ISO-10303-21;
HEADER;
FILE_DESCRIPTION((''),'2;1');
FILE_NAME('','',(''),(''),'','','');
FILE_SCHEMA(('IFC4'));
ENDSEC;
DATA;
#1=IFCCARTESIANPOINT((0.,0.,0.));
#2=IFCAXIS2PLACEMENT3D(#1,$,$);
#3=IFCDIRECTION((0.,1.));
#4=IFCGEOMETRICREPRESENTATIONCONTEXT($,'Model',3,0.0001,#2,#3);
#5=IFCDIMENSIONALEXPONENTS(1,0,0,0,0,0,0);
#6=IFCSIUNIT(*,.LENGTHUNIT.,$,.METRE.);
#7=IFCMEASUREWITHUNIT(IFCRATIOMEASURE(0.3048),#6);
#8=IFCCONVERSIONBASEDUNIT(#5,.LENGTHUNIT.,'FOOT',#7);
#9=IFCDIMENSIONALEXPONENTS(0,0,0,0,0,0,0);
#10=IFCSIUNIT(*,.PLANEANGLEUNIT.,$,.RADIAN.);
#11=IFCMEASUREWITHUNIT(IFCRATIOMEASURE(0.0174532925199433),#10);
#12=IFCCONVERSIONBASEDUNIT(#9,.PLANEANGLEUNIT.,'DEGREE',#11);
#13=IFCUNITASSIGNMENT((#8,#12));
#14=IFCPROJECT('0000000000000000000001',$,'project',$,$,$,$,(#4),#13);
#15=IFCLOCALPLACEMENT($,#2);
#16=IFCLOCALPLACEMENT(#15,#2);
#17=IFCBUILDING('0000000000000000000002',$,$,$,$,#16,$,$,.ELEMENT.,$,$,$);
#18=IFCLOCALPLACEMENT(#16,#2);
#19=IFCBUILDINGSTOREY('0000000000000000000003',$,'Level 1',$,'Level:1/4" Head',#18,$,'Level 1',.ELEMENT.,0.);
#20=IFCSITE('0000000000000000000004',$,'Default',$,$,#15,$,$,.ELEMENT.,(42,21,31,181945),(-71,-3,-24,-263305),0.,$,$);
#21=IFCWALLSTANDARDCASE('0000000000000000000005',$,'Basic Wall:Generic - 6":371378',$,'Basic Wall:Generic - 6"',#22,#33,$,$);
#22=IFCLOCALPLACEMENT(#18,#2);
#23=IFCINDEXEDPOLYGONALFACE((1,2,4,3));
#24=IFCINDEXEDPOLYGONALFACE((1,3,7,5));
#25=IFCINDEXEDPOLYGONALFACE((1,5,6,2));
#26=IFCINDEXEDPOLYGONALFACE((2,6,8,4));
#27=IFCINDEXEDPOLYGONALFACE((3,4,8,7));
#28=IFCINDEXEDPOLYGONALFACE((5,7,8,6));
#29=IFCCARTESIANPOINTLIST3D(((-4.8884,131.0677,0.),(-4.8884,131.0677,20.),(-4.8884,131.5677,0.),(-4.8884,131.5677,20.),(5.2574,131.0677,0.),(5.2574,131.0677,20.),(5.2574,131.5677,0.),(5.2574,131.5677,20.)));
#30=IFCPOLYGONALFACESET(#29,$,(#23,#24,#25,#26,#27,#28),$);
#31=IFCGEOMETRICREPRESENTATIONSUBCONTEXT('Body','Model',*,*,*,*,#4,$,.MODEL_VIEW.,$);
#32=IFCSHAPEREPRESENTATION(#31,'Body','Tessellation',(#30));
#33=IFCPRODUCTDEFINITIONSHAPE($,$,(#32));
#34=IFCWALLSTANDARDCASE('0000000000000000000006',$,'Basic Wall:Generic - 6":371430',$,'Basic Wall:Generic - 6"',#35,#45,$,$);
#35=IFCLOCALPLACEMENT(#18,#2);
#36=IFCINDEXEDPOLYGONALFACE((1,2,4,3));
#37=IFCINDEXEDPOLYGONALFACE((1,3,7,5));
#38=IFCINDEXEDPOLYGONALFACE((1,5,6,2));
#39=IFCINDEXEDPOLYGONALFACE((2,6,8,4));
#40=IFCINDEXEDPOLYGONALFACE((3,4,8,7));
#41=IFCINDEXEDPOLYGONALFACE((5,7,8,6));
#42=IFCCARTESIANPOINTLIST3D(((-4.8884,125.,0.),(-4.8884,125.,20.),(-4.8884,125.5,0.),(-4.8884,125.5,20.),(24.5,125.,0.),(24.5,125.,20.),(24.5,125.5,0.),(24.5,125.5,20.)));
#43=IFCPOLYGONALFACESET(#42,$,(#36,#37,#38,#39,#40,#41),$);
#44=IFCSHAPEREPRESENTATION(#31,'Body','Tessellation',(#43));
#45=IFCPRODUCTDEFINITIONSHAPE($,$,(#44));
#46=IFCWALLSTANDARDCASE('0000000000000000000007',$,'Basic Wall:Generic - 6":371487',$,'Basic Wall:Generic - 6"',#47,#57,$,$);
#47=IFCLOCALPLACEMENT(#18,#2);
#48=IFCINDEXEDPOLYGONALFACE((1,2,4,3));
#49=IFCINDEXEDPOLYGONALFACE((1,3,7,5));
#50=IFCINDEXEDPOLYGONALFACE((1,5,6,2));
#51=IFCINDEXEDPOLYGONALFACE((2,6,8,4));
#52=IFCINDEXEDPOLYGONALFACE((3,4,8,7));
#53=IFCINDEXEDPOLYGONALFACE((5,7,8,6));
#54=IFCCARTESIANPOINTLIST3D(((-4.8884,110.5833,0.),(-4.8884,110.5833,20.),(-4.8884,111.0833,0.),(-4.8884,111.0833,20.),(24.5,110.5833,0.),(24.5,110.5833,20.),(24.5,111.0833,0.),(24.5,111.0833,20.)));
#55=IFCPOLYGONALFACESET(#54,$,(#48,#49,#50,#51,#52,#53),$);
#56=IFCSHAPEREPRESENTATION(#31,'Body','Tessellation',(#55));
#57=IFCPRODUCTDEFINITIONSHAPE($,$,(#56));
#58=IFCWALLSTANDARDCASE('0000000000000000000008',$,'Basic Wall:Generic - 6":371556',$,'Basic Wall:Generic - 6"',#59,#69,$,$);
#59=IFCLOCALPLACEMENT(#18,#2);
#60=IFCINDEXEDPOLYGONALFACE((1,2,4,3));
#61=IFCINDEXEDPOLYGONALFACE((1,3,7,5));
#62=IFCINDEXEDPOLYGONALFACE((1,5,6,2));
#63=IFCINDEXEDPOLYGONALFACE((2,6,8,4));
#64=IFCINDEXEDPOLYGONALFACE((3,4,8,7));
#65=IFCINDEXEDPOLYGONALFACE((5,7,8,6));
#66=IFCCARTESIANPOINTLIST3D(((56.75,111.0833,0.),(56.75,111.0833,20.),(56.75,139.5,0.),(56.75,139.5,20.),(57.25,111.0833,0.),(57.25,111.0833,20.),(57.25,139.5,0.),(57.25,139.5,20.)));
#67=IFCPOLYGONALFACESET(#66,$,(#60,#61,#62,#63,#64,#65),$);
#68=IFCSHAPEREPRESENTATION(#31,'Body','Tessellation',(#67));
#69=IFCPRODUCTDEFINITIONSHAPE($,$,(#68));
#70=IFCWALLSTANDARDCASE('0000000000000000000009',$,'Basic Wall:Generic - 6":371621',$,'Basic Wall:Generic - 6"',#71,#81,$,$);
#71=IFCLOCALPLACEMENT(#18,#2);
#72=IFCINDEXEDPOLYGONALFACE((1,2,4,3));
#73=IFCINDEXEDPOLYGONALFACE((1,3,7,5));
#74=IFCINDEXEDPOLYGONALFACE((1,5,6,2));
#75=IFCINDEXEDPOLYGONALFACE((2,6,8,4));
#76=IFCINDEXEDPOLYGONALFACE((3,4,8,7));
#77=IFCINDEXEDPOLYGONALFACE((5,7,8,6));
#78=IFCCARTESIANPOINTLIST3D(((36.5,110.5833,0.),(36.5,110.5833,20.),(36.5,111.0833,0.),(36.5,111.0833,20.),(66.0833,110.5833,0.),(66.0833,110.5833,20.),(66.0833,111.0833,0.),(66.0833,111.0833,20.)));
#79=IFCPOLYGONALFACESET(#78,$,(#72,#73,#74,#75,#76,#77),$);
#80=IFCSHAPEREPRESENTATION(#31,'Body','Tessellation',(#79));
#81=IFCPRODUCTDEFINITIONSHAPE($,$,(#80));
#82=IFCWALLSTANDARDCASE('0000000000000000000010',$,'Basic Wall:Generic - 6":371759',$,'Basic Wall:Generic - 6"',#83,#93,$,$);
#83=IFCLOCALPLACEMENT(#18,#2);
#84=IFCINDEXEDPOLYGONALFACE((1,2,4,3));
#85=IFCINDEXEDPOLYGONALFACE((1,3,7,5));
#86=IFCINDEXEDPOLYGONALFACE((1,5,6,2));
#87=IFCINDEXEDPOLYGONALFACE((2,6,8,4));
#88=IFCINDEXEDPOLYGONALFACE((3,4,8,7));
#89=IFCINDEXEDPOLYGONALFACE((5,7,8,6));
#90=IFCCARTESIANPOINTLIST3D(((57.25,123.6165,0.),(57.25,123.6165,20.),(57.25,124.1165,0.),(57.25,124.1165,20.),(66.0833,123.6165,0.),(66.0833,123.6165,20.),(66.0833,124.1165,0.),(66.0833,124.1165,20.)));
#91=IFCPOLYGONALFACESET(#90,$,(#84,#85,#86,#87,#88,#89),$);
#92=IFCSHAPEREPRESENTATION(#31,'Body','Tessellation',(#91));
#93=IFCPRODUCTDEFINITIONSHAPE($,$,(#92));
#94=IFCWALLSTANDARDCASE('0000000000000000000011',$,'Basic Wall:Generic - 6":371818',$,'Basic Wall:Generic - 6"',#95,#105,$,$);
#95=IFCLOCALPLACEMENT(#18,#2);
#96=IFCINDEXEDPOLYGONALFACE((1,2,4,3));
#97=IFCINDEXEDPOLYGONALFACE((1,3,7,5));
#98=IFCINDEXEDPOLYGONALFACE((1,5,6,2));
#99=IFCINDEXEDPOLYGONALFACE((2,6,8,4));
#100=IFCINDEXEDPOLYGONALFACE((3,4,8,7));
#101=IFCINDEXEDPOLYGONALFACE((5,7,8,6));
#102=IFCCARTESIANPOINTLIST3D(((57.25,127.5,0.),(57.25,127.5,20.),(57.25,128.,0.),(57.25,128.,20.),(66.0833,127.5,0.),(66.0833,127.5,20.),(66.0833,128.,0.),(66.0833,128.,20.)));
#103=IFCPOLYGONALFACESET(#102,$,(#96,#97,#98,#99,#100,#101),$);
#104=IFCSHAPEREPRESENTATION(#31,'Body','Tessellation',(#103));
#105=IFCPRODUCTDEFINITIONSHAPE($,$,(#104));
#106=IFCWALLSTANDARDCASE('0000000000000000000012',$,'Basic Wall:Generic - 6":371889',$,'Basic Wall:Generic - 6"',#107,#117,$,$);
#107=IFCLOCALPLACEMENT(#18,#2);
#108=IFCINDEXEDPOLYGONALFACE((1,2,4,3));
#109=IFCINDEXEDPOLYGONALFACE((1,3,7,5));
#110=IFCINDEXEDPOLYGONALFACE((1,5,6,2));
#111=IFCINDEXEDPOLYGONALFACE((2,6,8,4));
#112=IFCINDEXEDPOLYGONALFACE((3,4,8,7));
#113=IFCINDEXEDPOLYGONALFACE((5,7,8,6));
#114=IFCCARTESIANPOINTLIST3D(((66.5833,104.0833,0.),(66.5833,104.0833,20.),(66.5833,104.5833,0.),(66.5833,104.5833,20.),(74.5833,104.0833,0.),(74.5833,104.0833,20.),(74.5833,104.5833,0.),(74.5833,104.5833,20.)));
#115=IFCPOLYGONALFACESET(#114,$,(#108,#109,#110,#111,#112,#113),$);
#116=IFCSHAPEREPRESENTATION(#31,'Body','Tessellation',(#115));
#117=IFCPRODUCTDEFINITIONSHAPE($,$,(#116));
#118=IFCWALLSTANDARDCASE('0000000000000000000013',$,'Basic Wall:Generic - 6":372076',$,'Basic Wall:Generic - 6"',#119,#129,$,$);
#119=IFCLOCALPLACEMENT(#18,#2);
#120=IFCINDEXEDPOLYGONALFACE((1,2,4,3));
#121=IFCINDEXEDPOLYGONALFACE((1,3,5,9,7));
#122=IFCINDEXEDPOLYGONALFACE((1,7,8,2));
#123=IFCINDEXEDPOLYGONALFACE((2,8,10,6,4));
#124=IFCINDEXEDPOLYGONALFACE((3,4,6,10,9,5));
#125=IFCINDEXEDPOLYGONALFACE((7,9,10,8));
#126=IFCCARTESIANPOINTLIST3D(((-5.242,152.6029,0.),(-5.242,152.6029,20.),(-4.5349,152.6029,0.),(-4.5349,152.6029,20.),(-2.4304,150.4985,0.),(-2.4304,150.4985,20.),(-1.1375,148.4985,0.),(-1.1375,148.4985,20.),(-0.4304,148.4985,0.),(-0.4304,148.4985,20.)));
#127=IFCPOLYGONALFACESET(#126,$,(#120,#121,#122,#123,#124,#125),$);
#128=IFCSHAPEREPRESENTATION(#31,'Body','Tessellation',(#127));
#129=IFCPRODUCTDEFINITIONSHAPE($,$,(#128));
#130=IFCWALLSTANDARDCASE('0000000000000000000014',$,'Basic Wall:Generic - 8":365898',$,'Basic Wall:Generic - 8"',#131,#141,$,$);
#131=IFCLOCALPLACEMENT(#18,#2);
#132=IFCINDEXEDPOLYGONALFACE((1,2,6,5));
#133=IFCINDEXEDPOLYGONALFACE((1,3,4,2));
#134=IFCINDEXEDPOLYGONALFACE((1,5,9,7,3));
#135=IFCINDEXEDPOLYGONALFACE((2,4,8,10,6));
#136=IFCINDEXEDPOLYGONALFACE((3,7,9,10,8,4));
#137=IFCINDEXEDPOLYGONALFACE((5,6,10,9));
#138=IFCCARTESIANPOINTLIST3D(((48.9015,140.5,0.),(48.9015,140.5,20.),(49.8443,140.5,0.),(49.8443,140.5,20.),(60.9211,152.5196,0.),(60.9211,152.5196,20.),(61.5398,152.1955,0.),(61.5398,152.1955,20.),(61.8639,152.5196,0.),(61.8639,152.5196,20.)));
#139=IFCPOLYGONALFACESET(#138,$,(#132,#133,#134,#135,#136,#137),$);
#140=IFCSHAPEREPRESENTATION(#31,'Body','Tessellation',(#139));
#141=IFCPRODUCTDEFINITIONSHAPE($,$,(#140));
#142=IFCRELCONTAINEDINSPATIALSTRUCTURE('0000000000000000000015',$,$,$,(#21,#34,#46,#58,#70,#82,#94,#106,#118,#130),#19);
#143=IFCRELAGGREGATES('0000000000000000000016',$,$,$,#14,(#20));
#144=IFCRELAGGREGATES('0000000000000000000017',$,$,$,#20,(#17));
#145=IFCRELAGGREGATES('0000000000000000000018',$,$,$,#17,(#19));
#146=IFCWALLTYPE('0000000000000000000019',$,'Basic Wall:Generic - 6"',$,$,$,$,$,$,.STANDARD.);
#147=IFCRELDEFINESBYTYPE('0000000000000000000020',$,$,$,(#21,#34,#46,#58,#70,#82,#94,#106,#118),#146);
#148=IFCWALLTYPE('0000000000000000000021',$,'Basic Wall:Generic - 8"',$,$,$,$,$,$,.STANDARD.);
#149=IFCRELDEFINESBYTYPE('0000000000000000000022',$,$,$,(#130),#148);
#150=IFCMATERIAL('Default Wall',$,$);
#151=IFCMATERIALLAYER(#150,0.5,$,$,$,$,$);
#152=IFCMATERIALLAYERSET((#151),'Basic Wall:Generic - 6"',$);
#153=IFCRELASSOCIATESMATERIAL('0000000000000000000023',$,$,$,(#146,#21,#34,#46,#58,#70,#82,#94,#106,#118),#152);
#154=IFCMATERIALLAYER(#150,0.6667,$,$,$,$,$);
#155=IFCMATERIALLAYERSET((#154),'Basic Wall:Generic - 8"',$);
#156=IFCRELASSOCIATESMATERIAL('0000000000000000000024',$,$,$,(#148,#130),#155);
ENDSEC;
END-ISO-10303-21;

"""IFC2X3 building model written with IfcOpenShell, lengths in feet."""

from ifc_helpers import new_model, entity, si_unit, converted_unit, direction, frame, frame_2d, origin, place, context, subcontext, project, spatial, polyline, rectangle, outline, extrude, material, layer, layer_set, layer_usage, type_object, element, save


model = new_model("IFC2X3")

# Units and contexts
model_context = context("Model", 3, precision=0.0001, world=origin(), true_north=direction((0.0, 1.0)))
body_context = subcontext(model_context, "Body", "Model", "MODEL_VIEW")
ifc_project = project(units=[converted_unit("LENGTHUNIT", "FOOT", entity("IfcRatioMeasure", 0.3048), si_unit("LENGTHUNIT", "METRE"), dimensions=[1, 0, 0, 0, 0, 0, 0]), converted_unit("PLANEANGLEUNIT", "DEGREE", entity("IfcRatioMeasure", 0.0174532925199433), si_unit("PLANEANGLEUNIT", "RADIAN"), dimensions=[0, 0, 0, 0, 0, 0, 0])], contexts=[model_context])

# Site, building, storey
site_placement = place(None, origin())
site = spatial("IfcSite", under=ifc_project, at=site_placement, Name="Default", CompositionType="ELEMENT", RefLatitude=(42, 21, 31, 181945), RefLongitude=(-71, -3, -24, -263305), RefElevation=0.0)
building_placement = place(site_placement, origin())
building = spatial("IfcBuilding", under=site, at=building_placement, CompositionType="ELEMENT")
storey_placement = place(building_placement, origin())
storey = spatial("IfcBuildingStorey", under=building, at=storey_placement, Name="Level 1", ObjectType="Level:1/4\" Head", LongName="Level 1", CompositionType="ELEMENT", Elevation=0.0)

# Walls
ifc_material = material(Name="Default Wall")
ifc_layer_1 = layer(ifc_material, 0.5)
ifc_layer_set_1 = layer_set([ifc_layer_1], Name="Basic Wall:Generic - 6\"")
wall_type_1 = type_object("IfcWallType", Name="Basic Wall:Generic - 6\"", PredefinedType="STANDARD", material=ifc_layer_set_1)
ifc_layer_usage_1 = layer_usage(ifc_layer_set_1, "AXIS2", "NEGATIVE", 0.25)
wall_1_placement = place(storey_placement, frame((5.2574, 131.3177, 0.0), z_axis=(0.0, 0.0, 1.0), x_axis=(-1.0, 0.0, 0.0)))
element("IfcWallStandardCase", 1, at=wall_1_placement, inside=storey, type_object=wall_type_1, material=ifc_layer_usage_1, Name="Basic Wall:Generic - 6\":371378", ObjectType="Basic Wall:Generic - 6\"", context=body_context, shape_type="SweptSolid", body=[
    extrude(rectangle(XDim=10.1458, YDim=0.5, at=frame_2d((5.0729, 0.0), x_axis=(-1.0, 0.0))), origin(), (0.0, 0.0, 1.0), 20.0),
])
ifc_layer_usage_2 = layer_usage(ifc_layer_set_1, "AXIS2", "NEGATIVE", 0.25)
wall_2_placement = place(storey_placement, frame((-4.8884, 125.25, 0.0)))
element("IfcWallStandardCase", 2, at=wall_2_placement, inside=storey, type_object=wall_type_1, material=ifc_layer_usage_2, Name="Basic Wall:Generic - 6\":371430", ObjectType="Basic Wall:Generic - 6\"", context=body_context, shape_type="SweptSolid", body=[
    extrude(rectangle(XDim=29.3884, YDim=0.5, at=frame_2d((14.6942, 0.0), x_axis=(-1.0, 0.0))), origin(), (0.0, 0.0, 1.0), 20.0),
])
ifc_layer_usage_3 = layer_usage(ifc_layer_set_1, "AXIS2", "NEGATIVE", 0.25)
wall_3_placement = place(storey_placement, frame((-4.8884, 110.8333, 0.0)))
element("IfcWallStandardCase", 3, at=wall_3_placement, inside=storey, type_object=wall_type_1, material=ifc_layer_usage_3, Name="Basic Wall:Generic - 6\":371487", ObjectType="Basic Wall:Generic - 6\"", context=body_context, shape_type="SweptSolid", body=[
    extrude(rectangle(XDim=29.3884, YDim=0.5, at=frame_2d((14.6942, 0.0), x_axis=(-1.0, 0.0))), origin(), (0.0, 0.0, 1.0), 20.0),
])
ifc_layer_usage_4 = layer_usage(ifc_layer_set_1, "AXIS2", "NEGATIVE", 0.25)
wall_4_placement = place(storey_placement, frame((57.0, 139.5, 0.0), z_axis=(0.0, 0.0, 1.0), x_axis=(0.0, -1.0, 0.0)))
element("IfcWallStandardCase", 4, at=wall_4_placement, inside=storey, type_object=wall_type_1, material=ifc_layer_usage_4, Name="Basic Wall:Generic - 6\":371556", ObjectType="Basic Wall:Generic - 6\"", context=body_context, shape_type="SweptSolid", body=[
    extrude(rectangle(XDim=28.4167, YDim=0.5, at=frame_2d((14.2083, 0.0), x_axis=(-1.0, 0.0))), origin(), (0.0, 0.0, 1.0), 20.0),
])
ifc_layer_usage_5 = layer_usage(ifc_layer_set_1, "AXIS2", "NEGATIVE", 0.25)
wall_5_placement = place(storey_placement, frame((66.0833, 110.8333, 0.0), z_axis=(0.0, 0.0, 1.0), x_axis=(-1.0, 0.0, 0.0)))
element("IfcWallStandardCase", 5, at=wall_5_placement, inside=storey, type_object=wall_type_1, material=ifc_layer_usage_5, Name="Basic Wall:Generic - 6\":371621", ObjectType="Basic Wall:Generic - 6\"", context=body_context, shape_type="SweptSolid", body=[
    extrude(rectangle(XDim=29.5833, YDim=0.5, at=frame_2d((14.7917, 0.0), x_axis=(-1.0, 0.0))), origin(), (0.0, 0.0, 1.0), 20.0),
])
ifc_layer_usage_6 = layer_usage(ifc_layer_set_1, "AXIS2", "NEGATIVE", 0.25)
wall_6_placement = place(storey_placement, frame((66.0833, 123.8665, 0.0), z_axis=(0.0, 0.0, 1.0), x_axis=(-1.0, 0.0, 0.0)))
element("IfcWallStandardCase", 6, at=wall_6_placement, inside=storey, type_object=wall_type_1, material=ifc_layer_usage_6, Name="Basic Wall:Generic - 6\":371759", ObjectType="Basic Wall:Generic - 6\"", context=body_context, shape_type="SweptSolid", body=[
    extrude(rectangle(XDim=8.8333, YDim=0.5, at=frame_2d((4.4167, 0.0), x_axis=(-1.0, 0.0))), origin(), (0.0, 0.0, 1.0), 20.0),
])
ifc_layer_usage_7 = layer_usage(ifc_layer_set_1, "AXIS2", "NEGATIVE", 0.25)
wall_7_placement = place(storey_placement, frame((66.0833, 127.75, 0.0), z_axis=(0.0, 0.0, 1.0), x_axis=(-1.0, 0.0, 0.0)))
element("IfcWallStandardCase", 7, at=wall_7_placement, inside=storey, type_object=wall_type_1, material=ifc_layer_usage_7, Name="Basic Wall:Generic - 6\":371818", ObjectType="Basic Wall:Generic - 6\"", context=body_context, shape_type="SweptSolid", body=[
    extrude(rectangle(XDim=8.8333, YDim=0.5, at=frame_2d((4.4167, 0.0), x_axis=(-1.0, 0.0))), origin(), (0.0, 0.0, 1.0), 20.0),
])
ifc_layer_usage_8 = layer_usage(ifc_layer_set_1, "AXIS2", "NEGATIVE", 0.25)
wall_8_placement = place(storey_placement, frame((66.5833, 104.3333, 0.0)))
element("IfcWallStandardCase", 8, at=wall_8_placement, inside=storey, type_object=wall_type_1, material=ifc_layer_usage_8, Name="Basic Wall:Generic - 6\":371889", ObjectType="Basic Wall:Generic - 6\"", context=body_context, shape_type="SweptSolid", body=[
    extrude(rectangle(XDim=8.0, YDim=0.5, at=frame_2d((4.0, 0.0), x_axis=(-1.0, 0.0))), origin(), (0.0, 0.0, 1.0), 20.0),
])
ifc_layer_usage_9 = layer_usage(ifc_layer_set_1, "AXIS2", "NEGATIVE", 0.25)
wall_9_placement = place(storey_placement, frame((-5.0652, 152.7797, 0.0), z_axis=(0.0, 0.0, 1.0), x_axis=(0.707107, -0.707107, 0.0)))
element("IfcWallStandardCase", 9, at=wall_9_placement, inside=storey, type_object=wall_type_1, material=ifc_layer_usage_9, Name="Basic Wall:Generic - 6\":372076", ObjectType="Basic Wall:Generic - 6\"", context=body_context, shape_type="SweptSolid", body=[
    extrude(outline(polyline([(5.8046, -0.25), (6.3046, 0.25), (3.4762, 0.25), (0.5, 0.25), (0.0, -0.25), (5.8046, -0.25)])), origin(), (0.0, 0.0, 1.0), 20.0),
])
ifc_layer_2 = layer(ifc_material, 0.6667)
ifc_layer_set_2 = layer_set([ifc_layer_2], Name="Basic Wall:Generic - 8\"")
ifc_layer_usage_10 = layer_usage(ifc_layer_set_2, "AXIS2", "NEGATIVE", 0.3333)
wall_type_2 = type_object("IfcWallType", Name="Basic Wall:Generic - 8\"", PredefinedType="STANDARD", material=ifc_layer_set_2)
wall_10_placement = place(storey_placement, frame((61.6282, 152.7553, 0.0), z_axis=(0.0, 0.0, 1.0), x_axis=(-0.707107, -0.707107, 0.0)))
element("IfcWallStandardCase", 10, at=wall_10_placement, inside=storey, type_object=wall_type_2, material=ifc_layer_usage_10, Name="Basic Wall:Generic - 8\":365898", ObjectType="Basic Wall:Generic - 8\"", context=body_context, shape_type="SweptSolid", body=[
    extrude(outline(polyline([(17.665, -0.3333), (16.9983, 0.3333), (0.4583, 0.3333), (0.0, 0.3333), (0.6667, -0.3333), (17.665, -0.3333)])), origin(), (0.0, 0.0, 1.0), 20.0),
])

save(model, "model.ifc")
